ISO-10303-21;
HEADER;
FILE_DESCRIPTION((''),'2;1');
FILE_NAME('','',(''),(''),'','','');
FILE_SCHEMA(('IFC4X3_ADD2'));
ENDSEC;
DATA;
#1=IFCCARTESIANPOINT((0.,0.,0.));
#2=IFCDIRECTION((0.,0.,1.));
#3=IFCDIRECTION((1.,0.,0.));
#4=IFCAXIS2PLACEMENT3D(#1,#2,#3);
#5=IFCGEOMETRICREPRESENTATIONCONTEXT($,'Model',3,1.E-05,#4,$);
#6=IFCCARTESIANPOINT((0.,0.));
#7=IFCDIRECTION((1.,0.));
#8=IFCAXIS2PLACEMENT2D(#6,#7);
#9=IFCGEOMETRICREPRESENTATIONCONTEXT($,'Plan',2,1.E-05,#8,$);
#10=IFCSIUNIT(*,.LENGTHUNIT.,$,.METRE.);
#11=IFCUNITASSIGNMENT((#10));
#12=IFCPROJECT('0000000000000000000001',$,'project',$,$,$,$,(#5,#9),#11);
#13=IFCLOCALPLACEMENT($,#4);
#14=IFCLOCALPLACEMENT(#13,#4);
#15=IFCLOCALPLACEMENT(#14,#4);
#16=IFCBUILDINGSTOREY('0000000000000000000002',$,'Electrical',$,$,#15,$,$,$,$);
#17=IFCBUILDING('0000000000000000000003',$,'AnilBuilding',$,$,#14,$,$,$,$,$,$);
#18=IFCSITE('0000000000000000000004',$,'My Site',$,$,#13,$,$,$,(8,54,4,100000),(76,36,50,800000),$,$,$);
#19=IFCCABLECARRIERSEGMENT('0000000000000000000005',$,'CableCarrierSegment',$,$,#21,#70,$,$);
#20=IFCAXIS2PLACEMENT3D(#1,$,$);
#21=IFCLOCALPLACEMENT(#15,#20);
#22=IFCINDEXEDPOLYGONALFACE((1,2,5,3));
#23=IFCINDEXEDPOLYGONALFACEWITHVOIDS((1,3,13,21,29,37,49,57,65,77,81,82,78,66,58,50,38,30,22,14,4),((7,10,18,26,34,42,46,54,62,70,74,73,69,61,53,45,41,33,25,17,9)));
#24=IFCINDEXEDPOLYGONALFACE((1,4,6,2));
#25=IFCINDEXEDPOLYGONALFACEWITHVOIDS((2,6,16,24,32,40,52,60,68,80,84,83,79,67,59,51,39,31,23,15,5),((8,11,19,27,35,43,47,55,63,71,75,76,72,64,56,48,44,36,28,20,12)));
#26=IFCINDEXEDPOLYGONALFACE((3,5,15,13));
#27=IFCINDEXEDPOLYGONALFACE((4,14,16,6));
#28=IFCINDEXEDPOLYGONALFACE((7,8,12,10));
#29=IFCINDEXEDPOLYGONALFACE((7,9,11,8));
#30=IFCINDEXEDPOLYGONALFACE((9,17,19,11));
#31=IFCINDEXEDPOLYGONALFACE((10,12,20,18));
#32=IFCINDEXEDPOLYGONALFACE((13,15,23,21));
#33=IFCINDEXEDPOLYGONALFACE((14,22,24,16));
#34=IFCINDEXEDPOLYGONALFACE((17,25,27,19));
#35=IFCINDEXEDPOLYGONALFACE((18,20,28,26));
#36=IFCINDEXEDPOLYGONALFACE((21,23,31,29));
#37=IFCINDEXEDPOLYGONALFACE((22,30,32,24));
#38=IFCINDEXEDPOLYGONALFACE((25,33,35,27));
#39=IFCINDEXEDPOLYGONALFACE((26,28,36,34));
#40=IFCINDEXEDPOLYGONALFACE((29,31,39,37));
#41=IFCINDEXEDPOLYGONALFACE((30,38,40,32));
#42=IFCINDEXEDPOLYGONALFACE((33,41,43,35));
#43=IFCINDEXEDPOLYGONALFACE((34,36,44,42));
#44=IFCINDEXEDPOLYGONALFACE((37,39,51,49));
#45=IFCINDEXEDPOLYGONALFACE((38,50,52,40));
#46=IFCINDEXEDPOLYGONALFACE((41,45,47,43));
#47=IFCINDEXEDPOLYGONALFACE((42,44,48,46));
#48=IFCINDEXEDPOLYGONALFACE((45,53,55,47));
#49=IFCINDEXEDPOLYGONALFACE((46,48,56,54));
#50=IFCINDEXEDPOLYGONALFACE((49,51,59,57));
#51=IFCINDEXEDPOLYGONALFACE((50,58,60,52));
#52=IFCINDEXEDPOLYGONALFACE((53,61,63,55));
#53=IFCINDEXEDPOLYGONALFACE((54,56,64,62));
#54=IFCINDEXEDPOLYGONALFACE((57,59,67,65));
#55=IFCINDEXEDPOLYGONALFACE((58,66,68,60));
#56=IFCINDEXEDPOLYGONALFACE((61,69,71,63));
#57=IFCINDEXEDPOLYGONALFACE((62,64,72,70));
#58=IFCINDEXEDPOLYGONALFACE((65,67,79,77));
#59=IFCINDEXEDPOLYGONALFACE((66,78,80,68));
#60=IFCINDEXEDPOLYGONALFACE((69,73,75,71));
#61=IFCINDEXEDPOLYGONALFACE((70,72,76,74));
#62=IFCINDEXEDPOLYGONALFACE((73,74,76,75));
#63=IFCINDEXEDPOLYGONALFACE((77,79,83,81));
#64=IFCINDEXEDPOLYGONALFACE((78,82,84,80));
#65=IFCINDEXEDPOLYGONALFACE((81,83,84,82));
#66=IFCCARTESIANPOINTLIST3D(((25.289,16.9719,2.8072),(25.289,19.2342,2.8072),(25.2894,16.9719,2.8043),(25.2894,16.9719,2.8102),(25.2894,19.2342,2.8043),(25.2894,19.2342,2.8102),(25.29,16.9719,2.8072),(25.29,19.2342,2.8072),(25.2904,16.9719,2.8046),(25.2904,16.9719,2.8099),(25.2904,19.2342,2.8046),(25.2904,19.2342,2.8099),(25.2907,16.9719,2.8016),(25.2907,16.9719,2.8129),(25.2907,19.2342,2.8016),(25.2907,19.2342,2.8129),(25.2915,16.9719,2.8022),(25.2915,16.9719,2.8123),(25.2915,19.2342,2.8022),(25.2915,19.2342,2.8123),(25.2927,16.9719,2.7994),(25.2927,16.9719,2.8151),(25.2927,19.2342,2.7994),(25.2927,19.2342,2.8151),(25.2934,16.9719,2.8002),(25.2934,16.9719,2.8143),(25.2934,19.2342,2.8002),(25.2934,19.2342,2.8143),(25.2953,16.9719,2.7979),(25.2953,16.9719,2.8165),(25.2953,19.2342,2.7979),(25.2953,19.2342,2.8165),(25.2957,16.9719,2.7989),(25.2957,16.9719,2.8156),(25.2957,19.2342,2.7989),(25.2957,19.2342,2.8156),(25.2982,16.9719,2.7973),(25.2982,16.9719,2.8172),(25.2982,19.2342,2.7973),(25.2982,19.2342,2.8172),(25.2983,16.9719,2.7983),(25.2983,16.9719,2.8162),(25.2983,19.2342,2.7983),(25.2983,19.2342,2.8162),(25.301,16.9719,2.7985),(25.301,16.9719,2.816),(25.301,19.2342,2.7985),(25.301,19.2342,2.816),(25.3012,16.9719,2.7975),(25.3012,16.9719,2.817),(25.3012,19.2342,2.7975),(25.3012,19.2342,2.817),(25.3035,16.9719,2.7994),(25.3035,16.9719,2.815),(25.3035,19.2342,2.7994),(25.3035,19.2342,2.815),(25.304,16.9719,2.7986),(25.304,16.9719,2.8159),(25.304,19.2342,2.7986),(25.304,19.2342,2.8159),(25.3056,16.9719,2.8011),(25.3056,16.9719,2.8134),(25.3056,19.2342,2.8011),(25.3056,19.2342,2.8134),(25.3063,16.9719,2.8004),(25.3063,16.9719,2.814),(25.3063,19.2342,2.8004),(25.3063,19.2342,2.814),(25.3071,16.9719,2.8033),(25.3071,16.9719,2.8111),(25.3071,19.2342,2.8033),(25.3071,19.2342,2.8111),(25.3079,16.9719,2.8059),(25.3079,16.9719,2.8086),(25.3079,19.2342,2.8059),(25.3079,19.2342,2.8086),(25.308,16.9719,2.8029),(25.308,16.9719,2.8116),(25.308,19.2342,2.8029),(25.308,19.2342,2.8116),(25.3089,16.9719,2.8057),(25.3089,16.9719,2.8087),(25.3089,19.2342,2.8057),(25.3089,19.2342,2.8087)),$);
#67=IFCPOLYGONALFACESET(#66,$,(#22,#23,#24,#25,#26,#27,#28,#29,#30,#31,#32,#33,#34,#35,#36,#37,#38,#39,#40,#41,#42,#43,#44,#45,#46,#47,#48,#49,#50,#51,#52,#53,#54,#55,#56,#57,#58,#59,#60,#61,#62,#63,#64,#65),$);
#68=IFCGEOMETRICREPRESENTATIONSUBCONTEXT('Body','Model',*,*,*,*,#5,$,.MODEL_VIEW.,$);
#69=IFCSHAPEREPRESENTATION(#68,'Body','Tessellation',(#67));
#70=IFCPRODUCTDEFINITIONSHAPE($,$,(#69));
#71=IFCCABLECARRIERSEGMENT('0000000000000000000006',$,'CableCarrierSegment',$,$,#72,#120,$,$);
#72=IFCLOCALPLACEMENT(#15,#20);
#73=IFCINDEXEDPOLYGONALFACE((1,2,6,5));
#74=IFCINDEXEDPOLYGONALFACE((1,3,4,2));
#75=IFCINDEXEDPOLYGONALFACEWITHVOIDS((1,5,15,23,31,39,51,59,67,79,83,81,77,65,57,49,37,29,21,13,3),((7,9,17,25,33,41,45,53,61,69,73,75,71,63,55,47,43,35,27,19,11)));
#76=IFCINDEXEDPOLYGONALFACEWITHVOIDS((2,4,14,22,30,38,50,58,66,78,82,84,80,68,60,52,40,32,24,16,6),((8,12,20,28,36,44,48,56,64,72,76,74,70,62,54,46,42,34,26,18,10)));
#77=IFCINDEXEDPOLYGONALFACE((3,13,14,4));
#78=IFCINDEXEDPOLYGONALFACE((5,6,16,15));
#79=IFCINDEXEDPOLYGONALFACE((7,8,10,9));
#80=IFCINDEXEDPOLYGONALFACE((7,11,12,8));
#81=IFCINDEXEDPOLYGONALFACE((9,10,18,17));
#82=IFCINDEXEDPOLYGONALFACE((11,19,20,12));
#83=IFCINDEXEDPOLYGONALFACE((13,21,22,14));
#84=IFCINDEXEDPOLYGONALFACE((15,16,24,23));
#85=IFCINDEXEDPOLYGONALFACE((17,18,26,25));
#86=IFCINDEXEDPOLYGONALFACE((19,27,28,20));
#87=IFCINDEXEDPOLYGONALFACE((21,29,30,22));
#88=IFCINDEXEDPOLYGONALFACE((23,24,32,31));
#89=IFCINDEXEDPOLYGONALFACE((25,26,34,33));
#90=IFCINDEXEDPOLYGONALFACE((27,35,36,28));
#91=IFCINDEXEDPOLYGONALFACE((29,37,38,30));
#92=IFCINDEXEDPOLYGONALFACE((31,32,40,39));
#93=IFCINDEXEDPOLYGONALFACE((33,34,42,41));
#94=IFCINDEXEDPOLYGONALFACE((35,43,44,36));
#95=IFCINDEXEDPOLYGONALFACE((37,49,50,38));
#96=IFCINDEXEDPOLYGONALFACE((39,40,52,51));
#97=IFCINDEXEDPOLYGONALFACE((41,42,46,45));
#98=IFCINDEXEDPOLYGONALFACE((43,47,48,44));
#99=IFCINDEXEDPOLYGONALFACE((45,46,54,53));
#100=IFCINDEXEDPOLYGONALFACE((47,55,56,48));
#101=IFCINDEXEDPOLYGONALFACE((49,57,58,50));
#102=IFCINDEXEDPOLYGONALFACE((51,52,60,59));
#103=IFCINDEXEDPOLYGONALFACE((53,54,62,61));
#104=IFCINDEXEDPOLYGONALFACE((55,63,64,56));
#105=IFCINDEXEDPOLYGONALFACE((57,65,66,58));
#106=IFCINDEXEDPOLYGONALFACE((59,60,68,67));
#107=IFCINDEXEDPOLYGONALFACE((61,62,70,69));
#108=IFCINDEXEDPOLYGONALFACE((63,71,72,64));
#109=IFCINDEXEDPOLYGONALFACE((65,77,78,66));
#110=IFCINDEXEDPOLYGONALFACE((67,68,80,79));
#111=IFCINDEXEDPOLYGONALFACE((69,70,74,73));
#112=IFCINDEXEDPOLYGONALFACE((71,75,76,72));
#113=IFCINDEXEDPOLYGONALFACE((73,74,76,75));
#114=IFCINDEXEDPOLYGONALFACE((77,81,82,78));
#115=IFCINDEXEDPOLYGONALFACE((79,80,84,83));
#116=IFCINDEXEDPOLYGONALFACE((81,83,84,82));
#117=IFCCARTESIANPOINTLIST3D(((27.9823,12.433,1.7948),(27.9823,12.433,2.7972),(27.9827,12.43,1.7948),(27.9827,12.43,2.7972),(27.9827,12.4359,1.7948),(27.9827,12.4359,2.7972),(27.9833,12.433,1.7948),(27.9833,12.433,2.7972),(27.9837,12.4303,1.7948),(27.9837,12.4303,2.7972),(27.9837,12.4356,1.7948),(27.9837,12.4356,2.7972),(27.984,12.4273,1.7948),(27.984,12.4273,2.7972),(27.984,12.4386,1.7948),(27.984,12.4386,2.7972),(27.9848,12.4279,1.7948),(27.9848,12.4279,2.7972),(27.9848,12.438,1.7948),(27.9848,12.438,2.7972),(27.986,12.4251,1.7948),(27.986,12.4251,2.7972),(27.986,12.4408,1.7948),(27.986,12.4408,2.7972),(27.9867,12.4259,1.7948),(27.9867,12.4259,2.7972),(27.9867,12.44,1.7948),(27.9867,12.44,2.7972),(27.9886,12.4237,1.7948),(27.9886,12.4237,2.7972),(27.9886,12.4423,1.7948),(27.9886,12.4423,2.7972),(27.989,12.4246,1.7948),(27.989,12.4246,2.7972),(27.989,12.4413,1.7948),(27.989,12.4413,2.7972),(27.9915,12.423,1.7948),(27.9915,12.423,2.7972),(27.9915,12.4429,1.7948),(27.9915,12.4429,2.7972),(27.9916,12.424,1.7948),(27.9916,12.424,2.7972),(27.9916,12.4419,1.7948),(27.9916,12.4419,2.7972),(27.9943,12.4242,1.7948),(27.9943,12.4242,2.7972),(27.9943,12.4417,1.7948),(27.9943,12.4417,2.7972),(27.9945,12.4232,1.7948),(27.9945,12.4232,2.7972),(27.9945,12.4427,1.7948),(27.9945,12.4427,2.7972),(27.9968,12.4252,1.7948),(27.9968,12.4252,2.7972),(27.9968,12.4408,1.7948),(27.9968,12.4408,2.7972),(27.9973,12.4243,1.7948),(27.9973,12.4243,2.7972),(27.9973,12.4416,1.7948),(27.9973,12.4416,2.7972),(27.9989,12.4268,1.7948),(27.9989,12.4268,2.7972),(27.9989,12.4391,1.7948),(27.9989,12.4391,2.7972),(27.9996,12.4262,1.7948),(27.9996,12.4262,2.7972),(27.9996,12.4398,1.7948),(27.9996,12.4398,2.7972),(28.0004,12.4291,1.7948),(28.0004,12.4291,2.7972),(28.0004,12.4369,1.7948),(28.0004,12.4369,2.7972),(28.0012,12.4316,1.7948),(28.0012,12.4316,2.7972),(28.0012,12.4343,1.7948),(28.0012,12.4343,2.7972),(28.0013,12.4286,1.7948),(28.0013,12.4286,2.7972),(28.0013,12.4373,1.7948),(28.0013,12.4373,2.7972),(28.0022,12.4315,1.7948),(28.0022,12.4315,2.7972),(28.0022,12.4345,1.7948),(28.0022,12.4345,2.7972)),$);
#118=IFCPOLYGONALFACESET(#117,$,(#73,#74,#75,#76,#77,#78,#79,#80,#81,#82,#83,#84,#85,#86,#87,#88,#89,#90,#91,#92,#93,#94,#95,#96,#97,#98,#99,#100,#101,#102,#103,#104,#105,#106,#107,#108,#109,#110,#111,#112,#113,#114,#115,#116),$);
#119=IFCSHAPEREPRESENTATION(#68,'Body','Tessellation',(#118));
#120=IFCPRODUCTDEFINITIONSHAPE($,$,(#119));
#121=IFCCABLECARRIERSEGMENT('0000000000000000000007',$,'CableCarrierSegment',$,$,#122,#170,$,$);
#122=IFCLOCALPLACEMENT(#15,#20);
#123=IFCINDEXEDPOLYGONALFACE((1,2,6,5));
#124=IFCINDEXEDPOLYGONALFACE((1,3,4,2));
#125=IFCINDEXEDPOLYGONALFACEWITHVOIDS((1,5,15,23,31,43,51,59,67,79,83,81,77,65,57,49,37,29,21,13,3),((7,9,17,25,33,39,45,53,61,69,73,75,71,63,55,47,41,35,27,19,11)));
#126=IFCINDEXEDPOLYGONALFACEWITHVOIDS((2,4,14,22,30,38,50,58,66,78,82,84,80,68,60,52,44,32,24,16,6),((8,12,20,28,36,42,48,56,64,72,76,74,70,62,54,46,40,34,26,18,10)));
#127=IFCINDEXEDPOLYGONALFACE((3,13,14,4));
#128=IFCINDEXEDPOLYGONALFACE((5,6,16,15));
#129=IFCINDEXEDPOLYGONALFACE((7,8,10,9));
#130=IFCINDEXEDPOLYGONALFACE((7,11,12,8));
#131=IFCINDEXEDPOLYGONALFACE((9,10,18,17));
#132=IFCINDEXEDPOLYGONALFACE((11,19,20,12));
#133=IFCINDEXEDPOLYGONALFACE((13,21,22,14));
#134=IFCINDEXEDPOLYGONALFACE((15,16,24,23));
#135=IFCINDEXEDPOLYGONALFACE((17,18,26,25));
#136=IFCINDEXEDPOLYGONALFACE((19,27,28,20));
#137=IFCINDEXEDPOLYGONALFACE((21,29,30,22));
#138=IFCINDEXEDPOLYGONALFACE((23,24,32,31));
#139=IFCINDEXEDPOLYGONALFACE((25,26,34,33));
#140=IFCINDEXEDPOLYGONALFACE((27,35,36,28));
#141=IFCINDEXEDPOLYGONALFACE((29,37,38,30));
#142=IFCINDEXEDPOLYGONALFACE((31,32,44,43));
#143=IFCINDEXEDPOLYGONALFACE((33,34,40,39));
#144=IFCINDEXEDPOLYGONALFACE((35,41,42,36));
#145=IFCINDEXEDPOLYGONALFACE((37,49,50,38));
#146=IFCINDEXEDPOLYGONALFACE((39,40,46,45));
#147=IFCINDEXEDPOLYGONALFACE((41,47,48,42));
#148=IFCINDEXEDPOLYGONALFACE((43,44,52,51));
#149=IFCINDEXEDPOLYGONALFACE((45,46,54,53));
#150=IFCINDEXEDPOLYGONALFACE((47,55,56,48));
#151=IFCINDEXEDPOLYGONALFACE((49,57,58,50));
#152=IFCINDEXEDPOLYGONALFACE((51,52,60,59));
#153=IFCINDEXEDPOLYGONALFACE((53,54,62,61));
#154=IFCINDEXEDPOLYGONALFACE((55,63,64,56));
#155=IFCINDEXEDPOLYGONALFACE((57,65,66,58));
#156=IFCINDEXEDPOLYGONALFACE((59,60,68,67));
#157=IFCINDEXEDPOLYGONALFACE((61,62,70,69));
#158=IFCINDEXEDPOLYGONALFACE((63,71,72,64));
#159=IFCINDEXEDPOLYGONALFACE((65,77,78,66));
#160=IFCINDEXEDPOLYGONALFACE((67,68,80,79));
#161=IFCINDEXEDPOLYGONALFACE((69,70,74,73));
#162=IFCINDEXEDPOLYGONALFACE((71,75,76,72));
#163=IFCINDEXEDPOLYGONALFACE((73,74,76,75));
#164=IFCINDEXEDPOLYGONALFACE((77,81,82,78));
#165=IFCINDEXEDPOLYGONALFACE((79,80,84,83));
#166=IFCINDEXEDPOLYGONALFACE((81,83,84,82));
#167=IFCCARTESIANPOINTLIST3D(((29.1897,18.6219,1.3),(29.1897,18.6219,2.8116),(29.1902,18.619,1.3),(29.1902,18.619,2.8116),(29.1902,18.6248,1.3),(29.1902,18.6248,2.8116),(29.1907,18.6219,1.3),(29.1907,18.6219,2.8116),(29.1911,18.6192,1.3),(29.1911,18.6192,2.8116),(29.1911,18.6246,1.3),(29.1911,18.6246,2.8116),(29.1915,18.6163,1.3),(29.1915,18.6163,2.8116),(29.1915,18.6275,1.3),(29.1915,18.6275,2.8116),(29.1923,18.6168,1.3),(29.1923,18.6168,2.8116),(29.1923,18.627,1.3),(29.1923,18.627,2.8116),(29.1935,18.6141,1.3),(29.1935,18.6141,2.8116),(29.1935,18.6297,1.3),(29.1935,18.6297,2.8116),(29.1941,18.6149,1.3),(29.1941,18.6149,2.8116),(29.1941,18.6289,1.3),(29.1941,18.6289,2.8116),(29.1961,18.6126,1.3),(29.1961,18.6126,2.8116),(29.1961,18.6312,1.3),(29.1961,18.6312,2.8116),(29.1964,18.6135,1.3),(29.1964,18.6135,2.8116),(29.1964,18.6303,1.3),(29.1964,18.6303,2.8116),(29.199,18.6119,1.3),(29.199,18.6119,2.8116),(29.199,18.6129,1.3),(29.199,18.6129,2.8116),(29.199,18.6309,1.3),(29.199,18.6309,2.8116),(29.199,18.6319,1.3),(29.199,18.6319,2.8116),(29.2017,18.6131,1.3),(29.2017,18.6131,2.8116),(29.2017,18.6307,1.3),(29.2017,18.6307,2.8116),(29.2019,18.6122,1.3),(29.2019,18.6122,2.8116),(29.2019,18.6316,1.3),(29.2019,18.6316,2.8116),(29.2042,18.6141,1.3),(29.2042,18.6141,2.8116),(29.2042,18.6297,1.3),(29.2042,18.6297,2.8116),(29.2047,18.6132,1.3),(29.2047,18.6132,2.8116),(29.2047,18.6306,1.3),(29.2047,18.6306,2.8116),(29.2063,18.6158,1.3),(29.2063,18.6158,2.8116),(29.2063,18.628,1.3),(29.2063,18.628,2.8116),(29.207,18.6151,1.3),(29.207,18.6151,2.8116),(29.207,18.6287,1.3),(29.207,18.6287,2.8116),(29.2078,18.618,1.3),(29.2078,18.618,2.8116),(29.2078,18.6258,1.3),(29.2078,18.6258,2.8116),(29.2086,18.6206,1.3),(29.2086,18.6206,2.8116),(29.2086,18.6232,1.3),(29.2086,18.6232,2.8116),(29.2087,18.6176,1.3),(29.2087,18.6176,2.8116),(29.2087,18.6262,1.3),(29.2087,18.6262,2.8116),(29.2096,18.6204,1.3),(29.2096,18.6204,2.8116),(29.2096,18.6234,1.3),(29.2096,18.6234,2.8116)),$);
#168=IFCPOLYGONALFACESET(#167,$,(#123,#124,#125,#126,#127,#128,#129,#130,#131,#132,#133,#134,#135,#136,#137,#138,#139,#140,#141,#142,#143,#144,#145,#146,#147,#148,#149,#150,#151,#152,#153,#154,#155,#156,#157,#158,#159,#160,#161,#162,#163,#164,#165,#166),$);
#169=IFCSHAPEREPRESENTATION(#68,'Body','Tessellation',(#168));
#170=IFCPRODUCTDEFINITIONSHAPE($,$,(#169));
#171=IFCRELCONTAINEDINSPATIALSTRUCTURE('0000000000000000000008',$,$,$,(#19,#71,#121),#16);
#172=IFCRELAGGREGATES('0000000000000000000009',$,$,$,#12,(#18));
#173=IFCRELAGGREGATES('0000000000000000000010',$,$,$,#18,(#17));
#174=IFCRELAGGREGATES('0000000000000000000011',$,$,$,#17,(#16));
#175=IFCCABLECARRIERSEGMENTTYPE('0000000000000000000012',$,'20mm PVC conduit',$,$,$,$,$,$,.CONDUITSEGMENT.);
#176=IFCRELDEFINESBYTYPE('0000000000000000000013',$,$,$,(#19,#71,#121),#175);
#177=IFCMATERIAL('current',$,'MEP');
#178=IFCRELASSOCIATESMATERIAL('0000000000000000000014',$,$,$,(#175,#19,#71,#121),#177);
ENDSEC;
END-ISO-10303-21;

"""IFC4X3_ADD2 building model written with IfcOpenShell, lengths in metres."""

from ifc_helpers import new_model, si_unit, frame, origin_with_axes, origin_2d_with_axis, place, context, subcontext, project, spatial, hollow_circle, extrude, material, material_profile, profile_set, profile_usage, type_object, element, save


model = new_model("IFC4X3_ADD2")

# Units and contexts
model_context = context("Model", 3, precision=1e-05, world=origin_with_axes())
plan_context = context("Plan", 2, precision=1e-05, world=origin_2d_with_axis())
body_context = subcontext(model_context, "Body", "Model", "MODEL_VIEW")
ifc_project = project(units=[si_unit("LENGTHUNIT", "METRE")], contexts=[model_context, plan_context])

# Site, building, storey
site_placement = place(None, origin_with_axes())
site = spatial("IfcSite", under=ifc_project, at=site_placement, Name="My Site", RefLatitude=(8, 54, 4, 100000), RefLongitude=(76, 36, 50, 800000))
building_placement = place(site_placement, origin_with_axes())
building = spatial("IfcBuilding", under=site, at=building_placement, Name="AnilBuilding")
storey_placement = place(building_placement, origin_with_axes())
storey = spatial("IfcBuildingStorey", under=building, at=storey_placement, Name="Electrical")

# Cable carrier segments
ifc_material = material(Name="current", Category="MEP")
ifc_material_profile_1 = material_profile(ifc_material, hollow_circle(Radius=0.01, WallThickness=0.001))
ifc_profile_set_1 = profile_set([ifc_material_profile_1], Name="current")
ifc_material_profile_2 = material_profile(ifc_material, hollow_circle(Radius=0.01, WallThickness=0.001))
ifc_profile_set_2 = profile_set([ifc_material_profile_2], Name="current")
cable_carrier_segment_type = type_object("IfcCableCarrierSegmentType", Name="20mm PVC conduit", PredefinedType="CONDUITSEGMENT", material=ifc_profile_set_2)
ifc_profile_usage_1 = profile_usage(ifc_profile_set_1, cardinal=5)
cable_carrier_segment_1_placement = place(storey_placement, frame((25.299, 16.9719, 2.8072), z_axis=(0.0, 1.0, 0.0), x_axis=(-1.0, 0.0, 0.0)))
element("IfcCableCarrierSegment", 1, at=cable_carrier_segment_1_placement, inside=storey, type_object=cable_carrier_segment_type, material=ifc_profile_usage_1, Name="CableCarrierSegment", context=body_context, shape_type="SweptSolid", body=[
    extrude(hollow_circle(Radius=0.01, WallThickness=0.001), origin_with_axes(), (0.0, 0.0, 1.0), 2.2622),
])
ifc_profile_usage_2 = profile_usage(ifc_profile_set_1, cardinal=5)
cable_carrier_segment_2_placement = place(storey_placement, frame((27.9923, 12.433, 1.7948), z_axis=(0.0, 0.0, 1.0), x_axis=(-1.0, 0.0, 0.0)))
element("IfcCableCarrierSegment", 2, at=cable_carrier_segment_2_placement, inside=storey, type_object=cable_carrier_segment_type, material=ifc_profile_usage_2, Name="CableCarrierSegment", context=body_context, shape_type="SweptSolid", body=[
    extrude(hollow_circle(Radius=0.01, WallThickness=0.001), origin_with_axes(), (0.0, 0.0, 1.0), 1.0024),
])
ifc_profile_usage_3 = profile_usage(ifc_profile_set_1, cardinal=5)
cable_carrier_segment_3_placement = place(storey_placement, frame((29.1997, 18.6219, 1.3), z_axis=(0.0, 0.0, 1.0), x_axis=(-1.0, 0.0, 0.0)))
element("IfcCableCarrierSegment", 3, at=cable_carrier_segment_3_placement, inside=storey, type_object=cable_carrier_segment_type, material=ifc_profile_usage_3, Name="CableCarrierSegment", context=body_context, shape_type="SweptSolid", body=[
    extrude(hollow_circle(Radius=0.01, WallThickness=0.001), origin_with_axes(), (0.0, 0.0, 1.0), 1.5116),
])

save(model, "model.ifc")
